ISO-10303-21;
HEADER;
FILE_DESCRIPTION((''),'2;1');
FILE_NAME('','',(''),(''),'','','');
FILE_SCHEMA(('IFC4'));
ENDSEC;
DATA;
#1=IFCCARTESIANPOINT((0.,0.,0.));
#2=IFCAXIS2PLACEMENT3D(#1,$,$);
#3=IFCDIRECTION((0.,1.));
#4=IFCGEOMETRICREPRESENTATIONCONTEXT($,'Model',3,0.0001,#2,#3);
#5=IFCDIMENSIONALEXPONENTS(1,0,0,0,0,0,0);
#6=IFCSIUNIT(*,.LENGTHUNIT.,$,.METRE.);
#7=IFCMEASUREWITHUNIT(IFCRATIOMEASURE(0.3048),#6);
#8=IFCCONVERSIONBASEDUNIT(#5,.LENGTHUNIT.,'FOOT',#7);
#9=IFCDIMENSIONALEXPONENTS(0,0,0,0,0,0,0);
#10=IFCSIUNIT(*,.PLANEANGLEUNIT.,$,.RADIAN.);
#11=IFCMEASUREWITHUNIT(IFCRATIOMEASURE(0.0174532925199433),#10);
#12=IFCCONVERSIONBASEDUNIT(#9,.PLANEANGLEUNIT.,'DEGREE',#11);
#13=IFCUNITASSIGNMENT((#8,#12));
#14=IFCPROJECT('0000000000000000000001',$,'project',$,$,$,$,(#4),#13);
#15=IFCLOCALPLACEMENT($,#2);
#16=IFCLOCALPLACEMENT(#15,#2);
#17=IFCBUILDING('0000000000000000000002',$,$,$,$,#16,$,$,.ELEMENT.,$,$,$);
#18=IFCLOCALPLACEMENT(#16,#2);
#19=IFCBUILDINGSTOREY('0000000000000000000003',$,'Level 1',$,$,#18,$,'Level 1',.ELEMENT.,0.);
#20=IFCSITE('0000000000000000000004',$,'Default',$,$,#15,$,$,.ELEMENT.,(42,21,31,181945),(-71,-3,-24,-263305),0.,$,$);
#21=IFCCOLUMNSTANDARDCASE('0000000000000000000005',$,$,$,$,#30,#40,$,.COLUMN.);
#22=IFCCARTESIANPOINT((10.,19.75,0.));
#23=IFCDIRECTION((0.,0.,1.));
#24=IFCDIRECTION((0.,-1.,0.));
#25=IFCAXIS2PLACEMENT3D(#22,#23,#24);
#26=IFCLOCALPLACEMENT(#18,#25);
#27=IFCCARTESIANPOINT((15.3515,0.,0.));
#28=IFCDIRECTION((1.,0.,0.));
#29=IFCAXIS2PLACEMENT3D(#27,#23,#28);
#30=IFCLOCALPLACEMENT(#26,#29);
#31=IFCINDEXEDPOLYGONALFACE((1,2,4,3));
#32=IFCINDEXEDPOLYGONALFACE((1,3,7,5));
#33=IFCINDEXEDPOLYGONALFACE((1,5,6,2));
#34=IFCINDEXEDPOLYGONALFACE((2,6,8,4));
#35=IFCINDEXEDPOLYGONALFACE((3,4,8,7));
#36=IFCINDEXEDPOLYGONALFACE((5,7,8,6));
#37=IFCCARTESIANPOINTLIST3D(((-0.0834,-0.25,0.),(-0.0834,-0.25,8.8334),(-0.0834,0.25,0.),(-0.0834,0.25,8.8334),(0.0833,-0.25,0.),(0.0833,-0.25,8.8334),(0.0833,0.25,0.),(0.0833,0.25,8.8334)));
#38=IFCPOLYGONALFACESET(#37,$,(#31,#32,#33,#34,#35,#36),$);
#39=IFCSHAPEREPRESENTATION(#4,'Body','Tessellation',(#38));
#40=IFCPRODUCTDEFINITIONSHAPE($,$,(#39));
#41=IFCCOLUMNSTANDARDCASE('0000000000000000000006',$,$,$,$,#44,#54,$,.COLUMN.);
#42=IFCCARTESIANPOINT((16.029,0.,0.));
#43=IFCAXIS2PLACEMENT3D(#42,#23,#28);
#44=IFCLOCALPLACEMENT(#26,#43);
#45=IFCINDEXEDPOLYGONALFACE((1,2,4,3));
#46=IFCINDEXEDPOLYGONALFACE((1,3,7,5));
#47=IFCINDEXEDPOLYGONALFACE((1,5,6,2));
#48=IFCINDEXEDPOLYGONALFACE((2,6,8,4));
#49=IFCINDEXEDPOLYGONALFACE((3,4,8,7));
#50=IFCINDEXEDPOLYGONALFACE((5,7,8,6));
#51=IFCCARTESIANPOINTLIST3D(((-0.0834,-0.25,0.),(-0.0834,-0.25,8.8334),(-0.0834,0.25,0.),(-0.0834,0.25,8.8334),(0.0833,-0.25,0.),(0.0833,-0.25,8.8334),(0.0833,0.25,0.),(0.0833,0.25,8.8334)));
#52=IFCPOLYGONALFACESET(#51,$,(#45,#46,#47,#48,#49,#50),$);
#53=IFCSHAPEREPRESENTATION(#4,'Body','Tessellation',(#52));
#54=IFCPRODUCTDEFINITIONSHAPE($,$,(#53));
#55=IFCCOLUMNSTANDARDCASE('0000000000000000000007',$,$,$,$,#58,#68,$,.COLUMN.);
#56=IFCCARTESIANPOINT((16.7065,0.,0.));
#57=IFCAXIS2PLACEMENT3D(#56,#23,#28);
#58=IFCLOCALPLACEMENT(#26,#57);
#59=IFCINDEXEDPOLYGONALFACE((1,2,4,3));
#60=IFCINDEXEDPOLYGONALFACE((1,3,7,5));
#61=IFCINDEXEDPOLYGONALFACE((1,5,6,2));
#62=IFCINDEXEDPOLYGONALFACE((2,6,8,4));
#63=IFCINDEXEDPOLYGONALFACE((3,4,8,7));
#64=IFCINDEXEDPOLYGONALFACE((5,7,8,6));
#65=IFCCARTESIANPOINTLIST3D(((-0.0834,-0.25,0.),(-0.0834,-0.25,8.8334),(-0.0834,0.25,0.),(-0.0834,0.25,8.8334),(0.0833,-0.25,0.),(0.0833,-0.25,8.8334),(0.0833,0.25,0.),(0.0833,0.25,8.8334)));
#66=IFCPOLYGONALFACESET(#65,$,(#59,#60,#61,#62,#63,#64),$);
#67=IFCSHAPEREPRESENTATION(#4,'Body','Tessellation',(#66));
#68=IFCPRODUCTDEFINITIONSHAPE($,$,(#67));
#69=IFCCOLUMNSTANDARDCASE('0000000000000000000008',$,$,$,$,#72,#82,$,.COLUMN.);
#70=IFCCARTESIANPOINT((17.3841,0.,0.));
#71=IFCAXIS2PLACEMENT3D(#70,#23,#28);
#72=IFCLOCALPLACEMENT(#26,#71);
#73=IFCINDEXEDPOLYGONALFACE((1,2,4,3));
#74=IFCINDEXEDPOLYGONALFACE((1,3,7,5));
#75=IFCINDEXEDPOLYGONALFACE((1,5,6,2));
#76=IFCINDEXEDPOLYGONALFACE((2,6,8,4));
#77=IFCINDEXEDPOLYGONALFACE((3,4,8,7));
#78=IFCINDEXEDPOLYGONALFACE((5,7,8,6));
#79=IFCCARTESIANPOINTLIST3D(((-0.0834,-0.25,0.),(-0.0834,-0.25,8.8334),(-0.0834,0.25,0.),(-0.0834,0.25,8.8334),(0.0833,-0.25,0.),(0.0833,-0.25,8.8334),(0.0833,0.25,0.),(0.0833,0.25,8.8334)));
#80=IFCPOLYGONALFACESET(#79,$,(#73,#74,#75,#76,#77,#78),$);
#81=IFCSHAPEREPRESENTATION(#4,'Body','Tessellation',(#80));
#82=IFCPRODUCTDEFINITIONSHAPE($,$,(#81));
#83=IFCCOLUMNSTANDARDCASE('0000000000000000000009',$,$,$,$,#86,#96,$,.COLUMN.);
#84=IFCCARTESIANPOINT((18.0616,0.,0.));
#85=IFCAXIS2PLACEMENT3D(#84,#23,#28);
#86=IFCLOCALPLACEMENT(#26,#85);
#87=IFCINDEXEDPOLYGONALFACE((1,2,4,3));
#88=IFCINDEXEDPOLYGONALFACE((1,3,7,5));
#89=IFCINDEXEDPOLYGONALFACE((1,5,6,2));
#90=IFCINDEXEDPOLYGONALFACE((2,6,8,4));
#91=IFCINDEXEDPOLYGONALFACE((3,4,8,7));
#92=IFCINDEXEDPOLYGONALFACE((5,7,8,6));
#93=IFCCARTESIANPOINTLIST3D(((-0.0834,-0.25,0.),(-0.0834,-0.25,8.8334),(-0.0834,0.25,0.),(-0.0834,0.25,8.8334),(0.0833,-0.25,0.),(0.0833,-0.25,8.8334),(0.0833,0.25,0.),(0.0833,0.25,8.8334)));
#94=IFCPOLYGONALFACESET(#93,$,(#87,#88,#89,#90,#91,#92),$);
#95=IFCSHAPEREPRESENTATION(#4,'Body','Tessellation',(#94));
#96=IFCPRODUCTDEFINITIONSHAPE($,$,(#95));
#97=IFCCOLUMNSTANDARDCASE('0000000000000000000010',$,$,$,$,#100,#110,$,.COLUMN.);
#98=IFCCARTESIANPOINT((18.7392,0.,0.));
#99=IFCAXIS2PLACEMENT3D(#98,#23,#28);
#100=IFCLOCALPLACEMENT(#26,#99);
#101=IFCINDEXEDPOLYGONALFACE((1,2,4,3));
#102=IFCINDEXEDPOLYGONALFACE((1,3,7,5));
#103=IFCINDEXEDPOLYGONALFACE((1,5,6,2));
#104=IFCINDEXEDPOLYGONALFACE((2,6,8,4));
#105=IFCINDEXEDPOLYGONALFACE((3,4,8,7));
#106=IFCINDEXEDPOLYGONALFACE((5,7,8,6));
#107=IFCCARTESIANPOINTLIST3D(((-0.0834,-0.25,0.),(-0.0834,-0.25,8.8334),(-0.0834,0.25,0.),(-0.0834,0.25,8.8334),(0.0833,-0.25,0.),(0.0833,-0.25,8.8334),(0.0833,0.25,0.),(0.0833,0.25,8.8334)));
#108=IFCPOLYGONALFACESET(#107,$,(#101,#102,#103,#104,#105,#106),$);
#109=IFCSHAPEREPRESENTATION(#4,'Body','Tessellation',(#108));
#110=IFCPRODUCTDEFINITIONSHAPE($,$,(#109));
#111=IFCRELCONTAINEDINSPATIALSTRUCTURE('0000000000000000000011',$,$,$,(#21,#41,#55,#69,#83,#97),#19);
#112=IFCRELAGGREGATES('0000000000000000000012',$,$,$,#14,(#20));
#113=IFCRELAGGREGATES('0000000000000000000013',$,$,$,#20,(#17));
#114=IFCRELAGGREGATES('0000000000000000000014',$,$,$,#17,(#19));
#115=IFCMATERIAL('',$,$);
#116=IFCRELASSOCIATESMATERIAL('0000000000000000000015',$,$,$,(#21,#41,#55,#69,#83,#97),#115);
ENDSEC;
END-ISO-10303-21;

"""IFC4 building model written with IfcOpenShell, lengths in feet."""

from ifc_helpers import new_model, entity, si_unit, converted_unit, direction, frame, origin, place, context, project, spatial, rectangle, extrude, material, element, save


model = new_model("IFC4")

# Units and contexts
model_context = context("Model", 3, precision=0.0001, world=origin(), true_north=direction((0.0, 1.0)))
ifc_project = project(units=[converted_unit("LENGTHUNIT", "FOOT", entity("IfcRatioMeasure", 0.3048), si_unit("LENGTHUNIT", "METRE"), dimensions=[1, 0, 0, 0, 0, 0, 0]), converted_unit("PLANEANGLEUNIT", "DEGREE", entity("IfcRatioMeasure", 0.0174532925199433), si_unit("PLANEANGLEUNIT", "RADIAN"), dimensions=[0, 0, 0, 0, 0, 0, 0])], contexts=[model_context])

# Site, building, storey
site_placement = place(None, origin())
site = spatial("IfcSite", under=ifc_project, at=site_placement, Name="Default", CompositionType="ELEMENT", RefLatitude=(42, 21, 31, 181945), RefLongitude=(-71, -3, -24, -263305), RefElevation=0.0)
building_placement = place(site_placement, origin())
building = spatial("IfcBuilding", under=site, at=building_placement, CompositionType="ELEMENT")
storey_placement = place(building_placement, origin())
storey = spatial("IfcBuildingStorey", under=building, at=storey_placement, Name="Level 1", LongName="Level 1", CompositionType="ELEMENT", Elevation=0.0)

# Columns
ifc_material_1 = material(Name="")
placement_1 = place(storey_placement, frame((10.0, 19.75, 0.0), z_axis=(0.0, 0.0, 1.0), x_axis=(0.0, -1.0, 0.0)))
for number, where, z_axis, x_axis in (
    (1, (15.3515, 0.0, 0.0), (0.0, 0.0, 1.0), (1.0, 0.0, 0.0)),
    (2, (16.029, 0.0, 0.0), (0.0, 0.0, 1.0), (1.0, 0.0, 0.0)),
    (3, (16.7065, 0.0, 0.0), (0.0, 0.0, 1.0), (1.0, 0.0, 0.0)),
    (4, (17.3841, 0.0, 0.0), (0.0, 0.0, 1.0), (1.0, 0.0, 0.0)),
    (5, (18.0616, 0.0, 0.0), (0.0, 0.0, 1.0), (1.0, 0.0, 0.0)),
    (6, (18.7392, 0.0, 0.0), (0.0, 0.0, 1.0), (1.0, 0.0, 0.0)),
):
    element("IfcColumnStandardCase", number, at=place(placement_1, frame(where, z_axis=z_axis, x_axis=x_axis)), inside=storey, material=ifc_material_1, PredefinedType="COLUMN", context=model_context, shape_type="SweptSolid", body=[
        extrude(rectangle(XDim=0.1667, YDim=0.5), origin(), (0.0, 0.0, 1.0), 8.8334),
    ])

save(model, "model.ifc")
